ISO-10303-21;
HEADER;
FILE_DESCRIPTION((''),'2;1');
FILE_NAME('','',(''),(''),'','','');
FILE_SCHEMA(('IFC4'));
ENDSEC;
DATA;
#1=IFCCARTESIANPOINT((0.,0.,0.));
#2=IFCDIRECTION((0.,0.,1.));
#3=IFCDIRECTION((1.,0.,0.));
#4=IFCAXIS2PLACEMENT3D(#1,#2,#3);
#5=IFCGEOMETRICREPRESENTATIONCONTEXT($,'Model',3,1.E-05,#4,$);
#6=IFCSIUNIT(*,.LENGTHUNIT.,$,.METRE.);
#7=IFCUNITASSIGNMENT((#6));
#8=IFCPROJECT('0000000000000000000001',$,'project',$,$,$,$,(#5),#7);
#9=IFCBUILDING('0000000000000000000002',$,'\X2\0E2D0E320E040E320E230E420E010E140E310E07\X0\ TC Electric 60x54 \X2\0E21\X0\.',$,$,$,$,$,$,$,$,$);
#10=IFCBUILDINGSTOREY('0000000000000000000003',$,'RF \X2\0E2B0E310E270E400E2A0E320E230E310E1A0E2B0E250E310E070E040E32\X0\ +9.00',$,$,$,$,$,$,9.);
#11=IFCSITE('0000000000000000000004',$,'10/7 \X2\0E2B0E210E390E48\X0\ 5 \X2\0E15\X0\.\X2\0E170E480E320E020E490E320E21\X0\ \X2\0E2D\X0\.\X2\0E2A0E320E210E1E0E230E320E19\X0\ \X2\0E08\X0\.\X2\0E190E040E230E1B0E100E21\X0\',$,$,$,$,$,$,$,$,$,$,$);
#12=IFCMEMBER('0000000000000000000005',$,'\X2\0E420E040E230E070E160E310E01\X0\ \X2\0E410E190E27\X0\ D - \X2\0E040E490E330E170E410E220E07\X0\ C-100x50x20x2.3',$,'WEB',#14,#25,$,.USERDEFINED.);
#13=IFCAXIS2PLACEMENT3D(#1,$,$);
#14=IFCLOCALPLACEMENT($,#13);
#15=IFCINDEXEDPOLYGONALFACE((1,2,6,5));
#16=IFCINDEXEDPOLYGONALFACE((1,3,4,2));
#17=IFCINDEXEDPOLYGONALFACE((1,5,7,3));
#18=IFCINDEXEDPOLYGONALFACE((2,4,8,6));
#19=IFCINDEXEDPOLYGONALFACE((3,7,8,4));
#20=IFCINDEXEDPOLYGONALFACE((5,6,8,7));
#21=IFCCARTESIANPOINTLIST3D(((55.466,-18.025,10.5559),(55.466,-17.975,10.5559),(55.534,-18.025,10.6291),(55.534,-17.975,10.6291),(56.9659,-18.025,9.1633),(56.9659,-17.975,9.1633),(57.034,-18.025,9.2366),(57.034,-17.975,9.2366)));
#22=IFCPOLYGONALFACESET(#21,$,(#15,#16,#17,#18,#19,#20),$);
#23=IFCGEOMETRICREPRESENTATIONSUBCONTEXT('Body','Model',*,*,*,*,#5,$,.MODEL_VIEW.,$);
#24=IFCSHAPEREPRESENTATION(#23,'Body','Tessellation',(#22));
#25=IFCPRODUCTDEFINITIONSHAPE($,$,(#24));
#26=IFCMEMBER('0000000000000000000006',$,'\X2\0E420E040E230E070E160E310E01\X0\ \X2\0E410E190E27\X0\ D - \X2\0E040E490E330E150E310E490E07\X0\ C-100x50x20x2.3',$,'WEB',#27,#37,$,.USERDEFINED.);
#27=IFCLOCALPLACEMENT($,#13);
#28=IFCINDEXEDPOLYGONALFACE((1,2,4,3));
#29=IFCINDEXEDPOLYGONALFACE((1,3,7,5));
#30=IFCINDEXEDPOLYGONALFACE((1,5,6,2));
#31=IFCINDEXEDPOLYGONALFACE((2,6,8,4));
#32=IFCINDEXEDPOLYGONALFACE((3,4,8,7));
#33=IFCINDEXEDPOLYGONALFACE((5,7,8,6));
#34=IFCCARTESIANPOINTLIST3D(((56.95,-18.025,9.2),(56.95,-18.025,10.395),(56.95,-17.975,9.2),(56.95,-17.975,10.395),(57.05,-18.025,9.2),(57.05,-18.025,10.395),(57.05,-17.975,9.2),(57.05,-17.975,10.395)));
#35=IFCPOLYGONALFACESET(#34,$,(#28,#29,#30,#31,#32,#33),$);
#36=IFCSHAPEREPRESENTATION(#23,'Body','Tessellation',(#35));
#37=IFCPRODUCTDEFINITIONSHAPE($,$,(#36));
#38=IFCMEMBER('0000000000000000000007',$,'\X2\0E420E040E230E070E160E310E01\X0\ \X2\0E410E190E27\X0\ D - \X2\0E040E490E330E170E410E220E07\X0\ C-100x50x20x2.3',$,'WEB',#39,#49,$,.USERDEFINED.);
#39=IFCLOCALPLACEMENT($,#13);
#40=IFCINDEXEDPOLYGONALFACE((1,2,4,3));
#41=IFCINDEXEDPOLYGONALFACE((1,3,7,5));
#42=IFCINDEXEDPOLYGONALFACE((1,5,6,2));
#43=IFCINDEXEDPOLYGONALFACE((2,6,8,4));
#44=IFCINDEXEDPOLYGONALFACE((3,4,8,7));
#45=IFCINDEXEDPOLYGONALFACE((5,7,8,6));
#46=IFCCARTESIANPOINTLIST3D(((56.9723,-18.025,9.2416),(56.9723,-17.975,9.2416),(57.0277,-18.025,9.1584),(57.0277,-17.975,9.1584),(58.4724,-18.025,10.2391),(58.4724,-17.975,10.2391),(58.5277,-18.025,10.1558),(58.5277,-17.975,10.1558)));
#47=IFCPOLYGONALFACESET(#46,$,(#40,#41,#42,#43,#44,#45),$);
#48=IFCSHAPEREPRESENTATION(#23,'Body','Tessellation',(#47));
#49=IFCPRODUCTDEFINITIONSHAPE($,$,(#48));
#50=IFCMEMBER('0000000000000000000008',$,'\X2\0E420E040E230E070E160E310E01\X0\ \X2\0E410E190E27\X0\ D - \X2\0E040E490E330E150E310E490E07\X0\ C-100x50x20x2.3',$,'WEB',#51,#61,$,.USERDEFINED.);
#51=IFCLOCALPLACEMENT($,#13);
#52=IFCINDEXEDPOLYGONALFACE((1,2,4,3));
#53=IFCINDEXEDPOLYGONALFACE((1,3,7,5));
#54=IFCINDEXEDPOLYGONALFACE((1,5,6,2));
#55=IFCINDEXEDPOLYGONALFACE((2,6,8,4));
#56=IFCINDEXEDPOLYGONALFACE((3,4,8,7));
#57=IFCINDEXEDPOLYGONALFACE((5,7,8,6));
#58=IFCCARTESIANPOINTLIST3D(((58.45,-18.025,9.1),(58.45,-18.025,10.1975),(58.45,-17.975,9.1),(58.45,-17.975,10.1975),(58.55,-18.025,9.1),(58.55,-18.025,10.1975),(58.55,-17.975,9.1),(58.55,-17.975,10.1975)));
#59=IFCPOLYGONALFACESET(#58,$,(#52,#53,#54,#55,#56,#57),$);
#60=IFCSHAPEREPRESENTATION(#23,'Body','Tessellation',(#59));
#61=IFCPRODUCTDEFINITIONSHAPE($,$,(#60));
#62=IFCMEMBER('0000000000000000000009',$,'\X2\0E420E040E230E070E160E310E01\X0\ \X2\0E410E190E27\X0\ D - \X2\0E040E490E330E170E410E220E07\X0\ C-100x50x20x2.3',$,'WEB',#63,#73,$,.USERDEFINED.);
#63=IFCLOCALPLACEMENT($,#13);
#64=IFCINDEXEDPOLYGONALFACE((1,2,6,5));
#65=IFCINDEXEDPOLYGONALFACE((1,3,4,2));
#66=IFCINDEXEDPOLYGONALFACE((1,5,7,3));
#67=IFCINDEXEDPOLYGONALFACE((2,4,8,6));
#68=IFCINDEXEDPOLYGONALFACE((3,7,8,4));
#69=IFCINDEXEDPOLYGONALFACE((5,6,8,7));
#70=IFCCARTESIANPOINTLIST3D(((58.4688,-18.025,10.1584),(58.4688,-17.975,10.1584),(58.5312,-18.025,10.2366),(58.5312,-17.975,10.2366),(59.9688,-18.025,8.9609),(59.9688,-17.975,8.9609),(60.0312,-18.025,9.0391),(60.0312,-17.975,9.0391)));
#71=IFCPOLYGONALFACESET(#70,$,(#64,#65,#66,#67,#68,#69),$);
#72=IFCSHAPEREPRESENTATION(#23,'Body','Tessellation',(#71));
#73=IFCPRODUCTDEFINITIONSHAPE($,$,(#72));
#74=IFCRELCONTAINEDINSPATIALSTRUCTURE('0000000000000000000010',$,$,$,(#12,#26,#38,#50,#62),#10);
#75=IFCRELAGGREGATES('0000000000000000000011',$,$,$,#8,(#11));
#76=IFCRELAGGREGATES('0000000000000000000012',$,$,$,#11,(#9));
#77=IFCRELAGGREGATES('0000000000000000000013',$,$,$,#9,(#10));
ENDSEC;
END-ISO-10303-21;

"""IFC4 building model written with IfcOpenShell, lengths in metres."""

from ifc_helpers import new_model, si_unit, frame, origin, origin_with_axes, origin_2d, place, context, subcontext, project, spatial, rectangle, extrude, element, save


model = new_model("IFC4")

# Units and contexts
model_context = context("Model", 3, precision=1e-05, world=origin_with_axes())
body_context = subcontext(model_context, "Body", "Model", "MODEL_VIEW")
ifc_project = project(units=[si_unit("LENGTHUNIT", "METRE")], contexts=[model_context])

# Site, building, storey
site = spatial("IfcSite", under=ifc_project, Name="10/7 หมู่ 5 ต.ท่าข้าม อ.สามพราน จ.นครปฐม")
building = spatial("IfcBuilding", under=site, Name="อาคารโกดัง TC Electric 60x54 ม.")
storey = spatial("IfcBuildingStorey", under=building, Name="RF หัวเสารับหลังคา +9.00", Elevation=9.0)

# Members
member_1_placement = place(None, frame((55.5, -18.0, 10.5925), z_axis=(0.7329, 0.0, -0.6804), x_axis=(0.0, -1.0, 0.0)))
element("IfcMember", 1, at=member_1_placement, inside=storey, Name="โครงถัก แนว D - ค้ำทแยง C-100x50x20x2.3", ObjectType="WEB", PredefinedType="USERDEFINED", context=body_context, shape_type="SweptSolid", body=[
    extrude(rectangle(XDim=0.05, YDim=0.1, at=origin_2d()), origin(), (0.0, 0.0, 1.0), 2.0467),
])
member_2_placement = place(None, frame((57.0, -18.0, 9.2), z_axis=(0.0, 0.0, 1.0), x_axis=(0.0, 1.0, 0.0)))
element("IfcMember", 2, at=member_2_placement, inside=storey, Name="โครงถัก แนว D - ค้ำตั้ง C-100x50x20x2.3", ObjectType="WEB", PredefinedType="USERDEFINED", context=body_context, shape_type="SweptSolid", body=[
    extrude(rectangle(XDim=0.05, YDim=0.1, at=origin_2d()), origin(), (0.0, 0.0, 1.0), 1.195),
])
member_3_placement = place(None, frame((57.0, -18.0, 9.2), z_axis=(0.8327, 0.0, 0.5537), x_axis=(0.0, -1.0, 0.0)))
element("IfcMember", 3, at=member_3_placement, inside=storey, Name="โครงถัก แนว D - ค้ำทแยง C-100x50x20x2.3", ObjectType="WEB", PredefinedType="USERDEFINED", context=body_context, shape_type="SweptSolid", body=[
    extrude(rectangle(XDim=0.05, YDim=0.1, at=origin_2d()), origin(), (0.0, 0.0, 1.0), 1.8014),
])
member_4_placement = place(None, frame((58.5, -18.0, 9.1), z_axis=(0.0, 0.0, 1.0), x_axis=(0.0, 1.0, 0.0)))
element("IfcMember", 4, at=member_4_placement, inside=storey, Name="โครงถัก แนว D - ค้ำตั้ง C-100x50x20x2.3", ObjectType="WEB", PredefinedType="USERDEFINED", context=body_context, shape_type="SweptSolid", body=[
    extrude(rectangle(XDim=0.05, YDim=0.1, at=origin_2d()), origin(), (0.0, 0.0, 1.0), 1.0975),
])
member_5_placement = place(None, frame((58.5, -18.0, 10.1975), z_axis=(0.7815, 0.0, -0.6239), x_axis=(0.0, -1.0, 0.0)))
element("IfcMember", 5, at=member_5_placement, inside=storey, Name="โครงถัก แนว D - ค้ำทแยง C-100x50x20x2.3", ObjectType="WEB", PredefinedType="USERDEFINED", context=body_context, shape_type="SweptSolid", body=[
    extrude(rectangle(XDim=0.05, YDim=0.1, at=origin_2d()), origin(), (0.0, 0.0, 1.0), 1.9194),
])

save(model, "model.ifc")
